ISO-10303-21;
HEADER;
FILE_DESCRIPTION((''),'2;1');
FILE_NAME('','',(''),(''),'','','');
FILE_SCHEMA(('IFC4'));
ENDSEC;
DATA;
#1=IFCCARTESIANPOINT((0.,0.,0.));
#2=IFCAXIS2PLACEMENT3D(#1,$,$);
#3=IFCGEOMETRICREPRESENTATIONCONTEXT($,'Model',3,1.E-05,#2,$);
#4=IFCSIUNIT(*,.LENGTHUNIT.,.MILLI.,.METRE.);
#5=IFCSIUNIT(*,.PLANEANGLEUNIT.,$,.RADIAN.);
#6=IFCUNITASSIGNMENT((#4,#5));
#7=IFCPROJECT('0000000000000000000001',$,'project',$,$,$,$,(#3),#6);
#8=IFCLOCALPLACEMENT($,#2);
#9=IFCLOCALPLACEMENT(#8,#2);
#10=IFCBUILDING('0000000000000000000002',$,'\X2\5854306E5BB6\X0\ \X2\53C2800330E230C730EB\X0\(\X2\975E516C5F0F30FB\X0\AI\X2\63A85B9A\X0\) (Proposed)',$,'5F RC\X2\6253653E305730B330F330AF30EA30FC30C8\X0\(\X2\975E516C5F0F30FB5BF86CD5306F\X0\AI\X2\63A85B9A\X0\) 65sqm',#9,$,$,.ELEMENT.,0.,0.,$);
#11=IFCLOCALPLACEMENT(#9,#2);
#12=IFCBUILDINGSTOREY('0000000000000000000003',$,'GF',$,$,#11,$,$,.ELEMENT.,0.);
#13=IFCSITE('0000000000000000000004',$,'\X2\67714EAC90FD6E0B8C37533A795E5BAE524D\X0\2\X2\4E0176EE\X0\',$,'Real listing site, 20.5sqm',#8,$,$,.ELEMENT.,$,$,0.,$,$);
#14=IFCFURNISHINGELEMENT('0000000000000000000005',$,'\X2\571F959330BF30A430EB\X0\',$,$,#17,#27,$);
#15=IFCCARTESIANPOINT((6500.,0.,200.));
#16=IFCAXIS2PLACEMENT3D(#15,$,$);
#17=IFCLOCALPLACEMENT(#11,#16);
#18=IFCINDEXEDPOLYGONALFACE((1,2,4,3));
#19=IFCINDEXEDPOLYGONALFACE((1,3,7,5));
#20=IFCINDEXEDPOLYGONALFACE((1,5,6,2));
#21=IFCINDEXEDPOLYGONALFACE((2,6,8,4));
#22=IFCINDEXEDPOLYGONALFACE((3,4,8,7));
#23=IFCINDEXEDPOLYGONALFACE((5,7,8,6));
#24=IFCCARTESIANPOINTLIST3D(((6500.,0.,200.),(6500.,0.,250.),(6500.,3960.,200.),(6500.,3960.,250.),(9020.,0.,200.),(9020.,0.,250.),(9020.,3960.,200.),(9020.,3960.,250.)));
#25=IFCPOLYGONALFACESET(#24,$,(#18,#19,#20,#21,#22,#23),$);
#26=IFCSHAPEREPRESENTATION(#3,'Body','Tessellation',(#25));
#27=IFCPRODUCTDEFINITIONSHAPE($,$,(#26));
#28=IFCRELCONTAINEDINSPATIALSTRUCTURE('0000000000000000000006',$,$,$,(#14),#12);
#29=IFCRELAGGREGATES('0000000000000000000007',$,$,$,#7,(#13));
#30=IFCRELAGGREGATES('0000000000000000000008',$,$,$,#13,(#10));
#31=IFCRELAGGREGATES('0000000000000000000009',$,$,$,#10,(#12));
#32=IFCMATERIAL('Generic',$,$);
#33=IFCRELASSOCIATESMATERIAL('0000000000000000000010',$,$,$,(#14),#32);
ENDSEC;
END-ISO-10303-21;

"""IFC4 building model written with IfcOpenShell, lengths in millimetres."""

from ifc_helpers import new_model, si_unit, frame, frame_2d, origin, place, context, project, spatial, rectangle, extrude, material, element, save


model = new_model("IFC4")

# Units and contexts
model_context = context("Model", 3, precision=1e-05, world=origin())
ifc_project = project(units=[si_unit("LENGTHUNIT", "METRE", prefix="MILLI"), si_unit("PLANEANGLEUNIT", "RADIAN")], contexts=[model_context])

# Site, building, storey
site_placement = place(None, origin())
site = spatial("IfcSite", under=ifc_project, at=site_placement, Name="東京都渋谷区神宮前2丁目", ObjectType="Real listing site, 20.5sqm", CompositionType="ELEMENT", RefElevation=0.0)
building_placement = place(site_placement, origin())
building = spatial("IfcBuilding", under=site, at=building_placement, Name="塔の家 参考モデル(非公式・AI推定) (Proposed)", ObjectType="5F RC打放しコンクリート(非公式・寸法はAI推定) 65sqm", CompositionType="ELEMENT", ElevationOfRefHeight=0.0, ElevationOfTerrain=0.0)
storey_placement = place(building_placement, origin())
storey = spatial("IfcBuildingStorey", under=building, at=storey_placement, Name="GF", CompositionType="ELEMENT", Elevation=0.0)

# Shared definitions
ifc_material = material(Name="Generic")

# Furnishing element
furnishing_1_placement = place(storey_placement, frame((6500.0, 0.0, 200.0)))
element("IfcFurnishingElement", 1, at=furnishing_1_placement, inside=storey, material=ifc_material, Name="土間タイル", context=model_context, shape_type="SweptSolid", body=[
    extrude(rectangle(XDim=2520.0, YDim=3960.0, at=frame_2d((1260.0, 1980.0))), frame((6500.0, 0.0, 200.0)), (0.0, 0.0, 1.0), 50.0),
])

save(model, "model.ifc")
